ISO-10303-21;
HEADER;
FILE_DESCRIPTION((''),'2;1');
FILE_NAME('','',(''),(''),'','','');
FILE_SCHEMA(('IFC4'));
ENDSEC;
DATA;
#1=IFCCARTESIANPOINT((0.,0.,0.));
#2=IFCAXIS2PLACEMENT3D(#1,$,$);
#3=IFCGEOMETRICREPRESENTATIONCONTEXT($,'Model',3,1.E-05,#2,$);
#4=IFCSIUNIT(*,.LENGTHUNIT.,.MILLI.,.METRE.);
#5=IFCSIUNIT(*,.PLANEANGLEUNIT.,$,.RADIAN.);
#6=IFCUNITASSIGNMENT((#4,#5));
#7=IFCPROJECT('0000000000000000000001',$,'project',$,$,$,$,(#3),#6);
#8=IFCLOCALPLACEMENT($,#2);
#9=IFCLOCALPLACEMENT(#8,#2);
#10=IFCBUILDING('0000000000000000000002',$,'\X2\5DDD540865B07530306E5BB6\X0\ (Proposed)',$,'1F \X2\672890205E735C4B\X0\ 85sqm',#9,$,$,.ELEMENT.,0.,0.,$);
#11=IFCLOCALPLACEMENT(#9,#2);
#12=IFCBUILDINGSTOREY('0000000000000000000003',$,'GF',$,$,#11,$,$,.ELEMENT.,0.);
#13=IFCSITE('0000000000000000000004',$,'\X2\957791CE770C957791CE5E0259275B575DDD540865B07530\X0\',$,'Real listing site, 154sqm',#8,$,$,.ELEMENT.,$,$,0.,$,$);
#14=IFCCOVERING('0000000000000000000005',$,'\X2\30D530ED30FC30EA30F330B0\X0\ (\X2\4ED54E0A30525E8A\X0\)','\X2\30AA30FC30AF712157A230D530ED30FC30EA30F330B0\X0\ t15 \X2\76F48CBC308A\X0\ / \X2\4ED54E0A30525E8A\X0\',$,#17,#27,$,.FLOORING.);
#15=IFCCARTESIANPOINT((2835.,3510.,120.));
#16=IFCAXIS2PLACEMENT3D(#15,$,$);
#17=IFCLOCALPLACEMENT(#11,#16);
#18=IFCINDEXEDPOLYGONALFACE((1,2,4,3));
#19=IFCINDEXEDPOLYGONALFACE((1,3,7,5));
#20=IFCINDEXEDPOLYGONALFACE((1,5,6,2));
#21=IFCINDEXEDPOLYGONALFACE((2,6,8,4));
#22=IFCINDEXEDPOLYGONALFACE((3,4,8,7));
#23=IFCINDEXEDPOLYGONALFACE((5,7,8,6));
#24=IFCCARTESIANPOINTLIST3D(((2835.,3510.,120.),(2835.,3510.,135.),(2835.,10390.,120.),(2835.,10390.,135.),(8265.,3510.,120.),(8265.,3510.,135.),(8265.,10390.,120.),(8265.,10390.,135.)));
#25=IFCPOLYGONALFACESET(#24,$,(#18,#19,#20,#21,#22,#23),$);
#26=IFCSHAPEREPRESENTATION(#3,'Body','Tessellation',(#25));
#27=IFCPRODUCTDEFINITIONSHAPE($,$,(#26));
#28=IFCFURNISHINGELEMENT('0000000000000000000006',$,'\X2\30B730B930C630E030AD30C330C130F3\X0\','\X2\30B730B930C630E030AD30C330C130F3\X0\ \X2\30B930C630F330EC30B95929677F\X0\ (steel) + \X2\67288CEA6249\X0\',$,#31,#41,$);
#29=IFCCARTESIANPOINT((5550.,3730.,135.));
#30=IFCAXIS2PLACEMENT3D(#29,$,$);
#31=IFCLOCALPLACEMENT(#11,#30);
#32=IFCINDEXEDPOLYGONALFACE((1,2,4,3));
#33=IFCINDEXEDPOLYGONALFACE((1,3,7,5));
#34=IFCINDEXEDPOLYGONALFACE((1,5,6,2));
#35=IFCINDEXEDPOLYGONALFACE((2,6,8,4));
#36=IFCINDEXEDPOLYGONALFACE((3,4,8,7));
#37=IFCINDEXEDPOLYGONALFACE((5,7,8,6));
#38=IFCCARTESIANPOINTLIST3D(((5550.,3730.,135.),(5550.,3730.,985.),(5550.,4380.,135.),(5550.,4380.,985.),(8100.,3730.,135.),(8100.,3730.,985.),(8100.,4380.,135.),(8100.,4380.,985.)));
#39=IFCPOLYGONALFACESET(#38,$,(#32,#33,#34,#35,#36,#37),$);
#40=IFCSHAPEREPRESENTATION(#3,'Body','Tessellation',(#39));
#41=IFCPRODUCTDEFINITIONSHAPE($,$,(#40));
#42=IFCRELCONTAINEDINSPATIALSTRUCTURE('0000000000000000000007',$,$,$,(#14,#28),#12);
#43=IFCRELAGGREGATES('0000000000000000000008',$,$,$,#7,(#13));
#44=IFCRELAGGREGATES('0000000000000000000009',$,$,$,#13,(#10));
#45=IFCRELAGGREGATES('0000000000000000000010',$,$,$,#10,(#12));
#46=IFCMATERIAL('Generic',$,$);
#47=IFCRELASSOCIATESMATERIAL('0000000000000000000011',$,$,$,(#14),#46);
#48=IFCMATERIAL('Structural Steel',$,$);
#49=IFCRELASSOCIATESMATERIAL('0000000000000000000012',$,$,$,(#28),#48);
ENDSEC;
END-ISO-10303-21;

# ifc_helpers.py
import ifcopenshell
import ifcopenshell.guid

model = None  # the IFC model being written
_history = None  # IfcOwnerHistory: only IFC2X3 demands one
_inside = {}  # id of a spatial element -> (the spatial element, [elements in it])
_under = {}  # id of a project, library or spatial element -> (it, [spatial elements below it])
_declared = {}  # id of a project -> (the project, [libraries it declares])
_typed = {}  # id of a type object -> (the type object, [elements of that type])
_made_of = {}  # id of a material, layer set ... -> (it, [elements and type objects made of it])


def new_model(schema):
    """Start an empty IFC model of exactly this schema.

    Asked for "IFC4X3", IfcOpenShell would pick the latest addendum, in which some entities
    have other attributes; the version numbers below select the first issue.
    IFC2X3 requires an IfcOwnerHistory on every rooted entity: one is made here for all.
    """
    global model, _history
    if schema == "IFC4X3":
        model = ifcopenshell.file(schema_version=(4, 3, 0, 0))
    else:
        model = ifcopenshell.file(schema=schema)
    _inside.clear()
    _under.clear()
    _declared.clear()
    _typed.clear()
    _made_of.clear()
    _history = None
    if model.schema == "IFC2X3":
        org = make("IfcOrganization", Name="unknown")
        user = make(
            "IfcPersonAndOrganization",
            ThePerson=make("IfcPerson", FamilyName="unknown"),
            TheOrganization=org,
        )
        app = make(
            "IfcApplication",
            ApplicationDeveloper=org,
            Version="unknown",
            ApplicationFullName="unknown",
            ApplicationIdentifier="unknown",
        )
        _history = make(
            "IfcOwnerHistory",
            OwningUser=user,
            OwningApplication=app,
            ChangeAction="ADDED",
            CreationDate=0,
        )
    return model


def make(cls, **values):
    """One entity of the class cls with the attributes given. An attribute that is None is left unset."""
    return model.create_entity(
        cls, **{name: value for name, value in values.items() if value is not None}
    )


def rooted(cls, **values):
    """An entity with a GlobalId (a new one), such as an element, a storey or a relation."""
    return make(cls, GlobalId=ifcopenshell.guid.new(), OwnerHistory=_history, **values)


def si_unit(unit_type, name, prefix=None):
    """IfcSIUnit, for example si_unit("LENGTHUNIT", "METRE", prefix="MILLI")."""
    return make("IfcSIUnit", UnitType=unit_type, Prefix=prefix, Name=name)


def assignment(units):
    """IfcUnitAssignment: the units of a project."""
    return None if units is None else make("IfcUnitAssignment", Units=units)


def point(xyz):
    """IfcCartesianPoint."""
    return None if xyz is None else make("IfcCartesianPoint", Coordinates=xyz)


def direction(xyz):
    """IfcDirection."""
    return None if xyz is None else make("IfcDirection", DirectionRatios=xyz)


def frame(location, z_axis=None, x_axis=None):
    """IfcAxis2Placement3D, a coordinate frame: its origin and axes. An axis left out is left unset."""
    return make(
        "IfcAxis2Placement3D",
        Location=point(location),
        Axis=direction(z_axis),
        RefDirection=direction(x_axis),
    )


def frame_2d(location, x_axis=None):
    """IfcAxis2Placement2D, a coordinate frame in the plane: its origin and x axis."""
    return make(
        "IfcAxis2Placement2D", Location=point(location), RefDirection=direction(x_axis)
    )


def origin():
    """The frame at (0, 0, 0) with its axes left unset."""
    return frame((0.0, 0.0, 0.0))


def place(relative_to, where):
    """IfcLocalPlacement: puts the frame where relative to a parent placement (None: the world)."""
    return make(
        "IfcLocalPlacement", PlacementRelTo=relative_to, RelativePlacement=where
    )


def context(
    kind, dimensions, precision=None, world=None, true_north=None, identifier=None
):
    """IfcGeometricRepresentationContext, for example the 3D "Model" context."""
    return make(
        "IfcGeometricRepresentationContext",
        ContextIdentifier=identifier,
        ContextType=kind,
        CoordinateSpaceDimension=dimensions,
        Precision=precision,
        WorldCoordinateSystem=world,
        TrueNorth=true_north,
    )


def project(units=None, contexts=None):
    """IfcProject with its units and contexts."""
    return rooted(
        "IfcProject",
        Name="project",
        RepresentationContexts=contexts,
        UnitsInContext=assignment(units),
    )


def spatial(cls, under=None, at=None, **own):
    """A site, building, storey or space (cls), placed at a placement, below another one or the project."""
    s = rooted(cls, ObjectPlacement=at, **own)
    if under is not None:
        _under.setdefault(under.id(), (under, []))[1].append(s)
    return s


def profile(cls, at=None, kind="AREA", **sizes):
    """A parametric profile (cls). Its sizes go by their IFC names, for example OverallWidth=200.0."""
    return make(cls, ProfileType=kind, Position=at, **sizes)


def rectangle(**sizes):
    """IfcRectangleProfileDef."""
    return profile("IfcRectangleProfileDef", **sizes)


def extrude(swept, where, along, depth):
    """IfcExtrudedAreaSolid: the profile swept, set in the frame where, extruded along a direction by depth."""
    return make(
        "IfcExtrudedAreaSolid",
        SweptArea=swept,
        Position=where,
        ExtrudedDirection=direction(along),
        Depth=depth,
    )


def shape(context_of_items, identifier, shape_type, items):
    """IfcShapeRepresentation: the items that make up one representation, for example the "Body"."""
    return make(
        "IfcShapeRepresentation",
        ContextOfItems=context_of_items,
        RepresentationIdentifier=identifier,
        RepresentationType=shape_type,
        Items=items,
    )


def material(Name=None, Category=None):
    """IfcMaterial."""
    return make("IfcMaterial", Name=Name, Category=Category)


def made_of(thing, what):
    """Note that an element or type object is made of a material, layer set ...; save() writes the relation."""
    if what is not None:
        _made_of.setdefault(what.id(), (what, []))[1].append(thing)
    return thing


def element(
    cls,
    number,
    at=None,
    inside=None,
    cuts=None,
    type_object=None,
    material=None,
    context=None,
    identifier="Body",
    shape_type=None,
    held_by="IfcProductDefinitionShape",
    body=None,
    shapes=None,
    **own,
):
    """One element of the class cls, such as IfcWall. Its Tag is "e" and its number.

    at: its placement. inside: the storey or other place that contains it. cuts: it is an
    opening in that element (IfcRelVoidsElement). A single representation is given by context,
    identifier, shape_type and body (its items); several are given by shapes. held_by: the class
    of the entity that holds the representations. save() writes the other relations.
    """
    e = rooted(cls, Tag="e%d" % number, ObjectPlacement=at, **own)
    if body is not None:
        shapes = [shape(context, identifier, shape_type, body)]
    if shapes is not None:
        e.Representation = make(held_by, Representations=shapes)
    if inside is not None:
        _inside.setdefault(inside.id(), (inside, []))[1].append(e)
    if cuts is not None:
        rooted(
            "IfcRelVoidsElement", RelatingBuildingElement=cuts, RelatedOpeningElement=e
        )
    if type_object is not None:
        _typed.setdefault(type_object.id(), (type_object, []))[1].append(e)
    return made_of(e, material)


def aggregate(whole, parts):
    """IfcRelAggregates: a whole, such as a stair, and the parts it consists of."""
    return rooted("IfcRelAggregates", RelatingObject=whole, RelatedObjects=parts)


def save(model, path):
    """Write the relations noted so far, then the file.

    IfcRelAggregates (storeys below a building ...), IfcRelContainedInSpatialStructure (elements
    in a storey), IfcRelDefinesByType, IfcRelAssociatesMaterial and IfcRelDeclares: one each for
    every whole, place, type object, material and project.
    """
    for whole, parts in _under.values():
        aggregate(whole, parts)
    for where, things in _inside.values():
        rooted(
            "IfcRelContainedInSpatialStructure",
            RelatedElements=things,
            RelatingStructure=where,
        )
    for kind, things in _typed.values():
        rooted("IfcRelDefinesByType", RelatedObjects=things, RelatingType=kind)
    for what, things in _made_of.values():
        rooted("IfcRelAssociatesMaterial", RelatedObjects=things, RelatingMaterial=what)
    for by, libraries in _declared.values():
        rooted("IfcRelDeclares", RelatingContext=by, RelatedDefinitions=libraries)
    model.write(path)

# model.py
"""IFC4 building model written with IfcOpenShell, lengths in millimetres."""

from ifc_helpers import new_model, si_unit, frame, frame_2d, origin, place, context, project, spatial, rectangle, extrude, material, element, save


model = new_model("IFC4")

# Units and contexts
model_context = context("Model", 3, precision=1e-05, world=origin())
ifc_project = project(units=[si_unit("LENGTHUNIT", "METRE", prefix="MILLI"), si_unit("PLANEANGLEUNIT", "RADIAN")], contexts=[model_context])

# Site, building, storey
site_placement = place(None, origin())
site = spatial("IfcSite", under=ifc_project, at=site_placement, Name="長野県長野市大字川合新田", ObjectType="Real listing site, 154sqm", CompositionType="ELEMENT", RefElevation=0.0)
building_placement = place(site_placement, origin())
building = spatial("IfcBuilding", under=site, at=building_placement, Name="川合新田の家 (Proposed)", ObjectType="1F 木造平屋 85sqm", CompositionType="ELEMENT", ElevationOfRefHeight=0.0, ElevationOfTerrain=0.0)
storey_placement = place(building_placement, origin())
storey = spatial("IfcBuildingStorey", under=building, at=storey_placement, Name="GF", CompositionType="ELEMENT", Elevation=0.0)

# Shared definitions
ifc_material_1 = material(Name="Generic")

# Covering
covering_placement = place(storey_placement, frame((2835.0, 3510.0, 120.0)))
element("IfcCovering", 1, at=covering_placement, inside=storey, material=ifc_material_1, Name="フローリング (仕上げ床)", Description="オーク無垢フローリング t15 直貼り / 仕上げ床", PredefinedType="FLOORING", context=model_context, shape_type="SweptSolid", body=[
    extrude(rectangle(XDim=5430.0, YDim=6880.0, at=frame_2d((2715.0, 3440.0))), frame((2835.0, 3510.0, 120.0)), (0.0, 0.0, 1.0), 15.0),
])

# Furnishing element
ifc_material_2 = material(Name="Structural Steel")
furnishing_placement = place(storey_placement, frame((5550.0, 3730.0, 135.0)))
element("IfcFurnishingElement", 2, at=furnishing_placement, inside=storey, material=ifc_material_2, Name="システムキッチン", Description="システムキッチン ステンレス天板 (steel) + 木質扉", context=model_context, shape_type="SweptSolid", body=[
    extrude(rectangle(XDim=2550.0, YDim=650.0, at=frame_2d((1275.0, 325.0))), frame((5550.0, 3730.0, 135.0)), (0.0, 0.0, 1.0), 850.0),
])

save(model, "model.ifc")
